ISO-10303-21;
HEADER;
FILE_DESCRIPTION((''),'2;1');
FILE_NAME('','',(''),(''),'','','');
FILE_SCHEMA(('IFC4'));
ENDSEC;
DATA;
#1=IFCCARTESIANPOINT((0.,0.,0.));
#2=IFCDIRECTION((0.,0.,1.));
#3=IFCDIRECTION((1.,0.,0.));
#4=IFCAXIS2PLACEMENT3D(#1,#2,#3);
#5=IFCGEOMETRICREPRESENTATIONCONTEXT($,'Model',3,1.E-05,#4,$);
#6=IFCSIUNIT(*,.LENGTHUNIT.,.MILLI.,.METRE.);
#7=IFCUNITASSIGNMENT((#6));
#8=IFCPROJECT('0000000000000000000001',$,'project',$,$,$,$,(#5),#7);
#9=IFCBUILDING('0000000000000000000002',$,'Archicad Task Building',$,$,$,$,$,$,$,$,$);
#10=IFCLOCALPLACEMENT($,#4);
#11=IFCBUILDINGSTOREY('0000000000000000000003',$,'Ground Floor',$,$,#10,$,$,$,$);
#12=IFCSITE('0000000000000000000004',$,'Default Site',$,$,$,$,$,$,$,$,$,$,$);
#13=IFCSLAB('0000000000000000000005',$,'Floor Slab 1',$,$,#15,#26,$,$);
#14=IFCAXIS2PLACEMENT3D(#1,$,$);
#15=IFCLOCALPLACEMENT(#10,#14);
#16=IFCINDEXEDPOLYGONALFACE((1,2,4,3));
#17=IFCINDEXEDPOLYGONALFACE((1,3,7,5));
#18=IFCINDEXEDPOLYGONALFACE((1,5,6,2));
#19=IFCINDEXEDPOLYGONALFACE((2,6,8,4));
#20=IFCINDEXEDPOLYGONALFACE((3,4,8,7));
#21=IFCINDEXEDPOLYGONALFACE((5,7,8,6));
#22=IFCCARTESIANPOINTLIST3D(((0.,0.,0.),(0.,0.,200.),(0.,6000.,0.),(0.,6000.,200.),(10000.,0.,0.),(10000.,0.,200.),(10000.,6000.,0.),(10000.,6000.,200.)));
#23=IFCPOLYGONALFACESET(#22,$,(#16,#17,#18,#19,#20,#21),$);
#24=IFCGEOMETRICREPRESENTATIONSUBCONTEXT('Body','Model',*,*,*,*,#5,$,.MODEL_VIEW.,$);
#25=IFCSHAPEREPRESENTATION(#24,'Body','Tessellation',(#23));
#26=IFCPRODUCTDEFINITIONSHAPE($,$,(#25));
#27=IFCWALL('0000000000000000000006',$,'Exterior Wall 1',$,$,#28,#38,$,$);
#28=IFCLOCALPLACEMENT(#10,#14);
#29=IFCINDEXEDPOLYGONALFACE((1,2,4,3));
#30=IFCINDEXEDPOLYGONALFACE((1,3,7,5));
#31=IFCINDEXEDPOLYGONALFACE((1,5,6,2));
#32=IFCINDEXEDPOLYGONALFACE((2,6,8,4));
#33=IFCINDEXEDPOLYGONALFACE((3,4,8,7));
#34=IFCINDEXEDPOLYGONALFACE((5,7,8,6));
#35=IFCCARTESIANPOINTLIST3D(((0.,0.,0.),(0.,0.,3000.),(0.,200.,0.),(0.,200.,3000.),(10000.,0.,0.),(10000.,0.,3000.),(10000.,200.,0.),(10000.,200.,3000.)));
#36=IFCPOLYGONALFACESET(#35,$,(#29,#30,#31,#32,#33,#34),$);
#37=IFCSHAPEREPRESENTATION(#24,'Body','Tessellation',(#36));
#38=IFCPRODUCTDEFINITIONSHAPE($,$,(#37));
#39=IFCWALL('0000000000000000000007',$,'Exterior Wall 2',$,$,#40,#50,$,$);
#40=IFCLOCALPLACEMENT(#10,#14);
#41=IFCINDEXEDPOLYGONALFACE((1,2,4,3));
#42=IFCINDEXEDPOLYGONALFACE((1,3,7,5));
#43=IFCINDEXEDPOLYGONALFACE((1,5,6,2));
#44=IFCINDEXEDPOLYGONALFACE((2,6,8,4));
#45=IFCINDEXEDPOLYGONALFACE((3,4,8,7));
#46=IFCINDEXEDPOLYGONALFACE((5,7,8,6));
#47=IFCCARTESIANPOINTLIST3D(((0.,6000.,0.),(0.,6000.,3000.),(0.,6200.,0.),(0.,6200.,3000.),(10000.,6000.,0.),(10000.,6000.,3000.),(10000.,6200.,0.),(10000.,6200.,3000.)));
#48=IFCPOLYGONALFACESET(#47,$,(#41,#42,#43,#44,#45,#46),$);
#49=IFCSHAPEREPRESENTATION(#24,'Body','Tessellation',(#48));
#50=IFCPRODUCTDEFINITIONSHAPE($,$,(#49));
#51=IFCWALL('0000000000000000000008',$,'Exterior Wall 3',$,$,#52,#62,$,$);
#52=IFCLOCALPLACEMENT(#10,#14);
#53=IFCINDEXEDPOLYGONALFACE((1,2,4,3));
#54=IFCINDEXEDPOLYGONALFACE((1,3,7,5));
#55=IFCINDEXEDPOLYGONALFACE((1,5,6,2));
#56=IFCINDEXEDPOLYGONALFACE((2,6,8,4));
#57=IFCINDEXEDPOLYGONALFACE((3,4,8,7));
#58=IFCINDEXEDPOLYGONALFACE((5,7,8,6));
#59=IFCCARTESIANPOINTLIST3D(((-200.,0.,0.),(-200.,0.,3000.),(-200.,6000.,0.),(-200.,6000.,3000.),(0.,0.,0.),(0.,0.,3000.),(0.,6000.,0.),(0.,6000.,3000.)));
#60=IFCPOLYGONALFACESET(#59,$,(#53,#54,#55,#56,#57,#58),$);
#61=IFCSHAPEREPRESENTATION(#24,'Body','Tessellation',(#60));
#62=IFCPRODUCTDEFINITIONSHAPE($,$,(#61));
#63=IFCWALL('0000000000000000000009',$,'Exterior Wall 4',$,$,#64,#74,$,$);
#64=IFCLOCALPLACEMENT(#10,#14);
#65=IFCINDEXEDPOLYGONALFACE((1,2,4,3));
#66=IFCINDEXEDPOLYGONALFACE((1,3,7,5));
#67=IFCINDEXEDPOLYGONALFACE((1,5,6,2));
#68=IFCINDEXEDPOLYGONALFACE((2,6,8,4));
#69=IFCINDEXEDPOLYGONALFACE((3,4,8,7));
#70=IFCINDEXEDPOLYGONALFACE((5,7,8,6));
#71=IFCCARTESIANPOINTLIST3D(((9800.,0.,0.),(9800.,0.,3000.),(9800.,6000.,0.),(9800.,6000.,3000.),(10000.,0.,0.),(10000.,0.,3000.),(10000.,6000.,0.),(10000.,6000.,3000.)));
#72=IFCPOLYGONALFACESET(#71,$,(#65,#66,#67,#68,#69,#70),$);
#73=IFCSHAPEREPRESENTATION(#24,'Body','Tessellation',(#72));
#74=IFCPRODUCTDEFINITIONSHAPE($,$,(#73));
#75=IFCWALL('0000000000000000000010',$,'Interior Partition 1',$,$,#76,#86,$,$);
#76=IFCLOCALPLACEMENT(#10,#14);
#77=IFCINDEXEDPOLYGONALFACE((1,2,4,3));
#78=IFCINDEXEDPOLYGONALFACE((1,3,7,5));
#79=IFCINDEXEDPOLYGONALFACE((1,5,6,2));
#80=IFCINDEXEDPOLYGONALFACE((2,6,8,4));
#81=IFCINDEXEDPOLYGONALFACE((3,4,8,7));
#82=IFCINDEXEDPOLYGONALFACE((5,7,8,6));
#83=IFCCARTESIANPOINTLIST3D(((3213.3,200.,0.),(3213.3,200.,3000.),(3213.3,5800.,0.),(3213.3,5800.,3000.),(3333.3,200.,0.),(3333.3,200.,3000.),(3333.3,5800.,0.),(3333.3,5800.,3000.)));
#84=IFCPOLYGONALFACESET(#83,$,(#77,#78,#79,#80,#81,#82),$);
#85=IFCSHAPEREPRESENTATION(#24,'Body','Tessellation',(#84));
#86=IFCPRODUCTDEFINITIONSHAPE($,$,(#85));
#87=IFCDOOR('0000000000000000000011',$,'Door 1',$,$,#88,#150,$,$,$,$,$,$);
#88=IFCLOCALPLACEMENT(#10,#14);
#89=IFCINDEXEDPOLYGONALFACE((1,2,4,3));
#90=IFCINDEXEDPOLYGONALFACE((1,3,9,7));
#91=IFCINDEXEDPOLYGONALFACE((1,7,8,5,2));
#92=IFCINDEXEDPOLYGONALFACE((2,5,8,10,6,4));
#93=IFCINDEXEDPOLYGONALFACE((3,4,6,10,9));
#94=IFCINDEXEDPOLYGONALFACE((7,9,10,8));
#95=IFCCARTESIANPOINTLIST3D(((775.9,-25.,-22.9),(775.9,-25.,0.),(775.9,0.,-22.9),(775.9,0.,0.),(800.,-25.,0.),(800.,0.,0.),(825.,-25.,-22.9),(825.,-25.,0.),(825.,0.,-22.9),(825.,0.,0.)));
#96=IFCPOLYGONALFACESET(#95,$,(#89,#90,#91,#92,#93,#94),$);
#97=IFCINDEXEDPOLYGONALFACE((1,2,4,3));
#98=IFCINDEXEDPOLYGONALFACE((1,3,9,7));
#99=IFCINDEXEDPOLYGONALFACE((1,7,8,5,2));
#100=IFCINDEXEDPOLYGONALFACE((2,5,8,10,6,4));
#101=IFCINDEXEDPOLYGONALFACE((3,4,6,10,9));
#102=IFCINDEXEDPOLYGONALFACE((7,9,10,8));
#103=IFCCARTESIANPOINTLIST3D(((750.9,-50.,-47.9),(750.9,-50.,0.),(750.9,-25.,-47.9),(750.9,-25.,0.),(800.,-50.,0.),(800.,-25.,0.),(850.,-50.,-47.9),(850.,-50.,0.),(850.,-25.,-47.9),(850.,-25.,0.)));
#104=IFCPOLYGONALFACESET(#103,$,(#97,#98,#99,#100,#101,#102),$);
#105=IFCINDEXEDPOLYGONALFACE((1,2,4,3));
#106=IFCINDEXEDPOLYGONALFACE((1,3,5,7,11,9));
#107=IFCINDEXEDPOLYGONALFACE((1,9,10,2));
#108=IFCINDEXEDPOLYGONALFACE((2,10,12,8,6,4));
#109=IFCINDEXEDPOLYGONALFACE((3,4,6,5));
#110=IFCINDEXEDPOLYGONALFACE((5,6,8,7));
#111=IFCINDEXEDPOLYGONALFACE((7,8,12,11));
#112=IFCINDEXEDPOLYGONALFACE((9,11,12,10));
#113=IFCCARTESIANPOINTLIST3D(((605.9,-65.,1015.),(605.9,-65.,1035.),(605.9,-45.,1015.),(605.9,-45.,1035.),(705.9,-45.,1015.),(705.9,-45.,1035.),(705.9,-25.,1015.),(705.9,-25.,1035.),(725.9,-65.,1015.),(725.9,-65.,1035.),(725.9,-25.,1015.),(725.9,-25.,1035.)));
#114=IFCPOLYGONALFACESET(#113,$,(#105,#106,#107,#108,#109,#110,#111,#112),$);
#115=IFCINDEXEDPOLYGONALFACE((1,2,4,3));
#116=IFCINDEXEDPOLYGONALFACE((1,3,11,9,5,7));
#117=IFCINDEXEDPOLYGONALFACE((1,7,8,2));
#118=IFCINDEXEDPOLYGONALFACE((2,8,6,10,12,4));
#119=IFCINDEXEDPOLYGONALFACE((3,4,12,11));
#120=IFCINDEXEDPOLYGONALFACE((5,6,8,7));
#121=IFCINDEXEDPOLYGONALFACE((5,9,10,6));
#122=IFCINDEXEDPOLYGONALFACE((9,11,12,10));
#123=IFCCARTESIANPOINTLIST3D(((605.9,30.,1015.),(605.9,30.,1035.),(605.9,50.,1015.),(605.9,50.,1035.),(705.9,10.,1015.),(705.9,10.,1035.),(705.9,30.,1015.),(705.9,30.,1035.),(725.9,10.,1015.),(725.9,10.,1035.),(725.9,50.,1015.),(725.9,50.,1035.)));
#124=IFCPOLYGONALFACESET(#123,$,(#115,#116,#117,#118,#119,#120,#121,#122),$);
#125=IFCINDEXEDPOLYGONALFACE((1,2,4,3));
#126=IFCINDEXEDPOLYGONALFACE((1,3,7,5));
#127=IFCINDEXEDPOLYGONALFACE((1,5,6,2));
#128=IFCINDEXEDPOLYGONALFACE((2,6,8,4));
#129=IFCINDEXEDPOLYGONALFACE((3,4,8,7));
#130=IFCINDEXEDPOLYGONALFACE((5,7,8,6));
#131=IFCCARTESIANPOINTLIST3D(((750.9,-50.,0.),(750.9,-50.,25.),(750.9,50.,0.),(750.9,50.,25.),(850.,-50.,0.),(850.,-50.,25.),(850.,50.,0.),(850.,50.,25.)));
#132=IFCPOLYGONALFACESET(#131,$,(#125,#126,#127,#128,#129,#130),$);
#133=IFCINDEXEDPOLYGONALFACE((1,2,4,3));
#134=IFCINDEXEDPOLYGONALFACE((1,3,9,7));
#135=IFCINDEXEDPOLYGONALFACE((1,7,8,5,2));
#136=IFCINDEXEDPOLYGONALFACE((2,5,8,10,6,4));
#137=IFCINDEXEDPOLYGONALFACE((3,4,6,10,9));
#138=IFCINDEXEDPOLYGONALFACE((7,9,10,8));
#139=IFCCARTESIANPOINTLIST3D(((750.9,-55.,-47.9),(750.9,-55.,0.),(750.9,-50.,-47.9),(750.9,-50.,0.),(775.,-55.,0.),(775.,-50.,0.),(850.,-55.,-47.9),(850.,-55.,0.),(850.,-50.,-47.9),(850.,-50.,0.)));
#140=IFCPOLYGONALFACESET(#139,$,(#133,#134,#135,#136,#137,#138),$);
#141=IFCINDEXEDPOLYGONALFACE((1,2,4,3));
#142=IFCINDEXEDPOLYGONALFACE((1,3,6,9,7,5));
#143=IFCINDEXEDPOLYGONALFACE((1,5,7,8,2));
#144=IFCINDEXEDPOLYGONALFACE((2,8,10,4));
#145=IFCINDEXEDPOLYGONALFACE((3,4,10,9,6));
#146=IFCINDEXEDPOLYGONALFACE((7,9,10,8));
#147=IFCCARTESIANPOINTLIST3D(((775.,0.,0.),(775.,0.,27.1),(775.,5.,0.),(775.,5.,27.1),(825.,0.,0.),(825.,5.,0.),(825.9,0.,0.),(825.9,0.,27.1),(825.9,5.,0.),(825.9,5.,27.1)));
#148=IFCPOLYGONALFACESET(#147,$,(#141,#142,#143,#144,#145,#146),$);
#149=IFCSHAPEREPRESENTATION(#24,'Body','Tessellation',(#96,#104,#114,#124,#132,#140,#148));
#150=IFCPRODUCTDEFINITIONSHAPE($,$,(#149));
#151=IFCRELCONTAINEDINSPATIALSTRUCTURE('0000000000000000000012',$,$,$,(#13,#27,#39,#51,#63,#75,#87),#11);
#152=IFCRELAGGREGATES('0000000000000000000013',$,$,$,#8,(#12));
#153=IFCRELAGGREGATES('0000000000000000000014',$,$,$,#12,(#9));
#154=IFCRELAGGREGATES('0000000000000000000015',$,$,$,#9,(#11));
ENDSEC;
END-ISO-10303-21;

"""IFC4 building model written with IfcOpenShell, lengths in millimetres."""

from ifc_helpers import new_model, si_unit, frame, origin_with_axes, place, context, subcontext, project, spatial, line, indexed_curve, outline, extrude, element, save


model = new_model("IFC4")

# Units and contexts
model_context = context("Model", 3, precision=1e-05, world=origin_with_axes())
body_context = subcontext(model_context, "Body", "Model", "MODEL_VIEW")
ifc_project = project(units=[si_unit("LENGTHUNIT", "METRE", prefix="MILLI")], contexts=[model_context])

# Site, building, storey
site = spatial("IfcSite", under=ifc_project, Name="Default Site")
building = spatial("IfcBuilding", under=site, Name="Archicad Task Building")
storey_placement = place(None, origin_with_axes())
storey = spatial("IfcBuildingStorey", under=building, at=storey_placement, Name="Ground Floor")

# Slab
slab_placement = place(storey_placement, origin_with_axes())
element("IfcSlab", 1, at=slab_placement, inside=storey, Name="Floor Slab 1", context=body_context, shape_type="SweptSolid", body=[
    extrude(outline(indexed_curve([(0.0, 0.0), (10000.0, 0.0), (10000.0, 6000.0), (0.0, 6000.0), (0.0, 0.0)])), None, (0.0, 0.0, 1.0), 200.0),
])

# Walls
for number, where, z_axis, x_axis, name in (
    (2, (0.0, 0.0, 0.0), (0.0, 0.0, 1.0), (1.0, 0.0, 0.0), "Exterior Wall 1"),
    (3, (0.0, 6000.0, 0.0), (0.0, 0.0, 1.0), (1.0, 0.0, 0.0), "Exterior Wall 2"),
):
    element("IfcWall", number, at=place(storey_placement, frame(where, z_axis=z_axis, x_axis=x_axis)), inside=storey, Name=name, context=body_context, shape_type="SweptSolid", body=[
        extrude(outline(indexed_curve([(0.0, 0.0), (0.0, 200.0), (10000.0, 200.0), (10000.0, 0.0), (0.0, 0.0)], self_intersect=False)), origin_with_axes(), (0.0, 0.0, 1.0), 3000.0),
    ])
for number, where, z_axis, x_axis, name in (
    (4, (0.0, 0.0, 0.0), (0.0, 0.0, 1.0), (0.0, 1.0, 0.0), "Exterior Wall 3"),
    (5, (10000.0, 0.0, 0.0), (0.0, 0.0, 1.0), (0.0, 1.0, 0.0), "Exterior Wall 4"),
):
    element("IfcWall", number, at=place(storey_placement, frame(where, z_axis=z_axis, x_axis=x_axis)), inside=storey, Name=name, context=body_context, shape_type="SweptSolid", body=[
        extrude(outline(indexed_curve([(0.0, 0.0), (0.0, 200.0), (6000.0, 200.0), (6000.0, 0.0), (0.0, 0.0)], self_intersect=False)), origin_with_axes(), (0.0, 0.0, 1.0), 3000.0),
    ])
wall_placement = place(storey_placement, frame((3333.3, 200.0, 0.0), z_axis=(0.0, 0.0, 1.0), x_axis=(0.0, 1.0, 0.0)))
element("IfcWall", 6, at=wall_placement, inside=storey, Name="Interior Partition 1", context=body_context, shape_type="SweptSolid", body=[
    extrude(outline(indexed_curve([(0.0, 0.0), (0.0, 120.0), (5600.0, 120.0), (5600.0, 0.0), (0.0, 0.0)], self_intersect=False)), origin_with_axes(), (0.0, 0.0, 1.0), 3000.0),
])

# Door
door_1_placement = place(storey_placement, frame((800.0, -50.0, 0.0), z_axis=(0.0, 0.0, 1.0), x_axis=(1.0, 0.0, 0.0)))
element("IfcDoor", 7, at=door_1_placement, inside=storey, Name="Door 1", context=body_context, shape_type="SweptSolid", body=[
    extrude(outline(indexed_curve([(0.0, 0.0), (0.0, 2.1), (0.9, 2.1), (0.9, 0.0), (-24.1, 0.0), (-24.1, -22.9), (25.0, -22.9), (25.0, 0.0)], segments=[line(1, 2, 3, 4, 5, 6, 7, 8, 1)])), frame((0.0, 25.0, 0.0), z_axis=(0.0, -1.0, 0.0), x_axis=(1.0, 0.0, 0.0)), (0.0, 0.0, -1.0), 25.0),
    extrude(outline(indexed_curve([(0.0, 0.0), (0.0, 2.1), (0.9, 2.1), (0.9, 0.0), (-49.1, 0.0), (-49.1, -47.9), (50.0, -47.9), (50.0, 0.0)], segments=[line(1, 2, 3, 4, 5, 6, 7, 8, 1)])), frame((0.0, 0.0, 0.0), z_axis=(0.0, -1.0, 0.0), x_axis=(1.0, 0.0, 0.0)), (0.0, 0.0, -1.0), 25.0),
    extrude(outline(indexed_curve([(0.0, 0.0), (-49.1, 0.0), (-49.1, 35.0), (0.0, 35.0)], segments=[line(1, 2, 3, 4, 1)])), frame((25.0, 25.0, 25.0), z_axis=(0.0, 0.0, 1.0), x_axis=(1.0, 0.0, 0.0)), (0.0, 0.0, 1.0), -47.9),
    extrude(outline(indexed_curve([(0.0, 0.0), (0.0, -40.0), (-120.0, -40.0), (-120.0, -20.0), (-20.0, -20.0), (-20.0, 0.0)], segments=[line(1, 2, 3, 4, 5, 6, 1)])), frame((-74.1, 25.0, 1015.0), z_axis=(0.0, 0.0, 1.0), x_axis=(1.0, 0.0, 0.0)), (0.0, 0.0, 1.0), 20.0),
    extrude(outline(indexed_curve([(0.0, 0.0), (0.0, 40.0), (-120.0, 40.0), (-120.0, 20.0), (-20.0, 20.0), (-20.0, 0.0)], segments=[line(1, 2, 3, 4, 5, 6, 1)])), frame((-74.1, 60.0, 1015.0), z_axis=(0.0, 0.0, 1.0), x_axis=(1.0, 0.0, 0.0)), (0.0, 0.0, 1.0), 20.0),
    extrude(outline(indexed_curve([(0.0, 0.0), (-99.1, 0.0), (-99.1, 100.0), (0.0, 100.0)], segments=[line(1, 2, 3, 4, 1)])), frame((50.0, 0.0, 0.0), z_axis=(0.0, 0.0, 1.0), x_axis=(1.0, 0.0, 0.0)), (0.0, 0.0, 1.0), 25.0),
    extrude(outline(indexed_curve([(0.0, 0.0), (0.0, 27.1), (50.9, 27.1), (50.9, 0.0), (-24.1, 0.0), (-24.1, -47.9), (75.0, -47.9), (75.0, 0.0)], segments=[line(1, 2, 3, 4, 5, 6, 7, 8, 1)])), frame((-25.0, -5.0, 0.0), z_axis=(0.0, -1.0, 0.0), x_axis=(1.0, 0.0, 0.0)), (0.0, 0.0, -1.0), 5.0),
    extrude(outline(indexed_curve([(0.0, 0.0), (0.0, 27.1), (50.9, 27.1), (50.9, 0.0), (0.9, 0.0), (0.9, -22.9), (50.0, -22.9), (50.0, 0.0)], segments=[line(1, 2, 3, 4, 5, 6, 7, 8, 1)])), frame((-25.0, 50.0, 0.0), z_axis=(0.0, -1.0, 0.0), x_axis=(1.0, 0.0, 0.0)), (0.0, 0.0, -1.0), 5.0),
])

save(model, "model.ifc")
